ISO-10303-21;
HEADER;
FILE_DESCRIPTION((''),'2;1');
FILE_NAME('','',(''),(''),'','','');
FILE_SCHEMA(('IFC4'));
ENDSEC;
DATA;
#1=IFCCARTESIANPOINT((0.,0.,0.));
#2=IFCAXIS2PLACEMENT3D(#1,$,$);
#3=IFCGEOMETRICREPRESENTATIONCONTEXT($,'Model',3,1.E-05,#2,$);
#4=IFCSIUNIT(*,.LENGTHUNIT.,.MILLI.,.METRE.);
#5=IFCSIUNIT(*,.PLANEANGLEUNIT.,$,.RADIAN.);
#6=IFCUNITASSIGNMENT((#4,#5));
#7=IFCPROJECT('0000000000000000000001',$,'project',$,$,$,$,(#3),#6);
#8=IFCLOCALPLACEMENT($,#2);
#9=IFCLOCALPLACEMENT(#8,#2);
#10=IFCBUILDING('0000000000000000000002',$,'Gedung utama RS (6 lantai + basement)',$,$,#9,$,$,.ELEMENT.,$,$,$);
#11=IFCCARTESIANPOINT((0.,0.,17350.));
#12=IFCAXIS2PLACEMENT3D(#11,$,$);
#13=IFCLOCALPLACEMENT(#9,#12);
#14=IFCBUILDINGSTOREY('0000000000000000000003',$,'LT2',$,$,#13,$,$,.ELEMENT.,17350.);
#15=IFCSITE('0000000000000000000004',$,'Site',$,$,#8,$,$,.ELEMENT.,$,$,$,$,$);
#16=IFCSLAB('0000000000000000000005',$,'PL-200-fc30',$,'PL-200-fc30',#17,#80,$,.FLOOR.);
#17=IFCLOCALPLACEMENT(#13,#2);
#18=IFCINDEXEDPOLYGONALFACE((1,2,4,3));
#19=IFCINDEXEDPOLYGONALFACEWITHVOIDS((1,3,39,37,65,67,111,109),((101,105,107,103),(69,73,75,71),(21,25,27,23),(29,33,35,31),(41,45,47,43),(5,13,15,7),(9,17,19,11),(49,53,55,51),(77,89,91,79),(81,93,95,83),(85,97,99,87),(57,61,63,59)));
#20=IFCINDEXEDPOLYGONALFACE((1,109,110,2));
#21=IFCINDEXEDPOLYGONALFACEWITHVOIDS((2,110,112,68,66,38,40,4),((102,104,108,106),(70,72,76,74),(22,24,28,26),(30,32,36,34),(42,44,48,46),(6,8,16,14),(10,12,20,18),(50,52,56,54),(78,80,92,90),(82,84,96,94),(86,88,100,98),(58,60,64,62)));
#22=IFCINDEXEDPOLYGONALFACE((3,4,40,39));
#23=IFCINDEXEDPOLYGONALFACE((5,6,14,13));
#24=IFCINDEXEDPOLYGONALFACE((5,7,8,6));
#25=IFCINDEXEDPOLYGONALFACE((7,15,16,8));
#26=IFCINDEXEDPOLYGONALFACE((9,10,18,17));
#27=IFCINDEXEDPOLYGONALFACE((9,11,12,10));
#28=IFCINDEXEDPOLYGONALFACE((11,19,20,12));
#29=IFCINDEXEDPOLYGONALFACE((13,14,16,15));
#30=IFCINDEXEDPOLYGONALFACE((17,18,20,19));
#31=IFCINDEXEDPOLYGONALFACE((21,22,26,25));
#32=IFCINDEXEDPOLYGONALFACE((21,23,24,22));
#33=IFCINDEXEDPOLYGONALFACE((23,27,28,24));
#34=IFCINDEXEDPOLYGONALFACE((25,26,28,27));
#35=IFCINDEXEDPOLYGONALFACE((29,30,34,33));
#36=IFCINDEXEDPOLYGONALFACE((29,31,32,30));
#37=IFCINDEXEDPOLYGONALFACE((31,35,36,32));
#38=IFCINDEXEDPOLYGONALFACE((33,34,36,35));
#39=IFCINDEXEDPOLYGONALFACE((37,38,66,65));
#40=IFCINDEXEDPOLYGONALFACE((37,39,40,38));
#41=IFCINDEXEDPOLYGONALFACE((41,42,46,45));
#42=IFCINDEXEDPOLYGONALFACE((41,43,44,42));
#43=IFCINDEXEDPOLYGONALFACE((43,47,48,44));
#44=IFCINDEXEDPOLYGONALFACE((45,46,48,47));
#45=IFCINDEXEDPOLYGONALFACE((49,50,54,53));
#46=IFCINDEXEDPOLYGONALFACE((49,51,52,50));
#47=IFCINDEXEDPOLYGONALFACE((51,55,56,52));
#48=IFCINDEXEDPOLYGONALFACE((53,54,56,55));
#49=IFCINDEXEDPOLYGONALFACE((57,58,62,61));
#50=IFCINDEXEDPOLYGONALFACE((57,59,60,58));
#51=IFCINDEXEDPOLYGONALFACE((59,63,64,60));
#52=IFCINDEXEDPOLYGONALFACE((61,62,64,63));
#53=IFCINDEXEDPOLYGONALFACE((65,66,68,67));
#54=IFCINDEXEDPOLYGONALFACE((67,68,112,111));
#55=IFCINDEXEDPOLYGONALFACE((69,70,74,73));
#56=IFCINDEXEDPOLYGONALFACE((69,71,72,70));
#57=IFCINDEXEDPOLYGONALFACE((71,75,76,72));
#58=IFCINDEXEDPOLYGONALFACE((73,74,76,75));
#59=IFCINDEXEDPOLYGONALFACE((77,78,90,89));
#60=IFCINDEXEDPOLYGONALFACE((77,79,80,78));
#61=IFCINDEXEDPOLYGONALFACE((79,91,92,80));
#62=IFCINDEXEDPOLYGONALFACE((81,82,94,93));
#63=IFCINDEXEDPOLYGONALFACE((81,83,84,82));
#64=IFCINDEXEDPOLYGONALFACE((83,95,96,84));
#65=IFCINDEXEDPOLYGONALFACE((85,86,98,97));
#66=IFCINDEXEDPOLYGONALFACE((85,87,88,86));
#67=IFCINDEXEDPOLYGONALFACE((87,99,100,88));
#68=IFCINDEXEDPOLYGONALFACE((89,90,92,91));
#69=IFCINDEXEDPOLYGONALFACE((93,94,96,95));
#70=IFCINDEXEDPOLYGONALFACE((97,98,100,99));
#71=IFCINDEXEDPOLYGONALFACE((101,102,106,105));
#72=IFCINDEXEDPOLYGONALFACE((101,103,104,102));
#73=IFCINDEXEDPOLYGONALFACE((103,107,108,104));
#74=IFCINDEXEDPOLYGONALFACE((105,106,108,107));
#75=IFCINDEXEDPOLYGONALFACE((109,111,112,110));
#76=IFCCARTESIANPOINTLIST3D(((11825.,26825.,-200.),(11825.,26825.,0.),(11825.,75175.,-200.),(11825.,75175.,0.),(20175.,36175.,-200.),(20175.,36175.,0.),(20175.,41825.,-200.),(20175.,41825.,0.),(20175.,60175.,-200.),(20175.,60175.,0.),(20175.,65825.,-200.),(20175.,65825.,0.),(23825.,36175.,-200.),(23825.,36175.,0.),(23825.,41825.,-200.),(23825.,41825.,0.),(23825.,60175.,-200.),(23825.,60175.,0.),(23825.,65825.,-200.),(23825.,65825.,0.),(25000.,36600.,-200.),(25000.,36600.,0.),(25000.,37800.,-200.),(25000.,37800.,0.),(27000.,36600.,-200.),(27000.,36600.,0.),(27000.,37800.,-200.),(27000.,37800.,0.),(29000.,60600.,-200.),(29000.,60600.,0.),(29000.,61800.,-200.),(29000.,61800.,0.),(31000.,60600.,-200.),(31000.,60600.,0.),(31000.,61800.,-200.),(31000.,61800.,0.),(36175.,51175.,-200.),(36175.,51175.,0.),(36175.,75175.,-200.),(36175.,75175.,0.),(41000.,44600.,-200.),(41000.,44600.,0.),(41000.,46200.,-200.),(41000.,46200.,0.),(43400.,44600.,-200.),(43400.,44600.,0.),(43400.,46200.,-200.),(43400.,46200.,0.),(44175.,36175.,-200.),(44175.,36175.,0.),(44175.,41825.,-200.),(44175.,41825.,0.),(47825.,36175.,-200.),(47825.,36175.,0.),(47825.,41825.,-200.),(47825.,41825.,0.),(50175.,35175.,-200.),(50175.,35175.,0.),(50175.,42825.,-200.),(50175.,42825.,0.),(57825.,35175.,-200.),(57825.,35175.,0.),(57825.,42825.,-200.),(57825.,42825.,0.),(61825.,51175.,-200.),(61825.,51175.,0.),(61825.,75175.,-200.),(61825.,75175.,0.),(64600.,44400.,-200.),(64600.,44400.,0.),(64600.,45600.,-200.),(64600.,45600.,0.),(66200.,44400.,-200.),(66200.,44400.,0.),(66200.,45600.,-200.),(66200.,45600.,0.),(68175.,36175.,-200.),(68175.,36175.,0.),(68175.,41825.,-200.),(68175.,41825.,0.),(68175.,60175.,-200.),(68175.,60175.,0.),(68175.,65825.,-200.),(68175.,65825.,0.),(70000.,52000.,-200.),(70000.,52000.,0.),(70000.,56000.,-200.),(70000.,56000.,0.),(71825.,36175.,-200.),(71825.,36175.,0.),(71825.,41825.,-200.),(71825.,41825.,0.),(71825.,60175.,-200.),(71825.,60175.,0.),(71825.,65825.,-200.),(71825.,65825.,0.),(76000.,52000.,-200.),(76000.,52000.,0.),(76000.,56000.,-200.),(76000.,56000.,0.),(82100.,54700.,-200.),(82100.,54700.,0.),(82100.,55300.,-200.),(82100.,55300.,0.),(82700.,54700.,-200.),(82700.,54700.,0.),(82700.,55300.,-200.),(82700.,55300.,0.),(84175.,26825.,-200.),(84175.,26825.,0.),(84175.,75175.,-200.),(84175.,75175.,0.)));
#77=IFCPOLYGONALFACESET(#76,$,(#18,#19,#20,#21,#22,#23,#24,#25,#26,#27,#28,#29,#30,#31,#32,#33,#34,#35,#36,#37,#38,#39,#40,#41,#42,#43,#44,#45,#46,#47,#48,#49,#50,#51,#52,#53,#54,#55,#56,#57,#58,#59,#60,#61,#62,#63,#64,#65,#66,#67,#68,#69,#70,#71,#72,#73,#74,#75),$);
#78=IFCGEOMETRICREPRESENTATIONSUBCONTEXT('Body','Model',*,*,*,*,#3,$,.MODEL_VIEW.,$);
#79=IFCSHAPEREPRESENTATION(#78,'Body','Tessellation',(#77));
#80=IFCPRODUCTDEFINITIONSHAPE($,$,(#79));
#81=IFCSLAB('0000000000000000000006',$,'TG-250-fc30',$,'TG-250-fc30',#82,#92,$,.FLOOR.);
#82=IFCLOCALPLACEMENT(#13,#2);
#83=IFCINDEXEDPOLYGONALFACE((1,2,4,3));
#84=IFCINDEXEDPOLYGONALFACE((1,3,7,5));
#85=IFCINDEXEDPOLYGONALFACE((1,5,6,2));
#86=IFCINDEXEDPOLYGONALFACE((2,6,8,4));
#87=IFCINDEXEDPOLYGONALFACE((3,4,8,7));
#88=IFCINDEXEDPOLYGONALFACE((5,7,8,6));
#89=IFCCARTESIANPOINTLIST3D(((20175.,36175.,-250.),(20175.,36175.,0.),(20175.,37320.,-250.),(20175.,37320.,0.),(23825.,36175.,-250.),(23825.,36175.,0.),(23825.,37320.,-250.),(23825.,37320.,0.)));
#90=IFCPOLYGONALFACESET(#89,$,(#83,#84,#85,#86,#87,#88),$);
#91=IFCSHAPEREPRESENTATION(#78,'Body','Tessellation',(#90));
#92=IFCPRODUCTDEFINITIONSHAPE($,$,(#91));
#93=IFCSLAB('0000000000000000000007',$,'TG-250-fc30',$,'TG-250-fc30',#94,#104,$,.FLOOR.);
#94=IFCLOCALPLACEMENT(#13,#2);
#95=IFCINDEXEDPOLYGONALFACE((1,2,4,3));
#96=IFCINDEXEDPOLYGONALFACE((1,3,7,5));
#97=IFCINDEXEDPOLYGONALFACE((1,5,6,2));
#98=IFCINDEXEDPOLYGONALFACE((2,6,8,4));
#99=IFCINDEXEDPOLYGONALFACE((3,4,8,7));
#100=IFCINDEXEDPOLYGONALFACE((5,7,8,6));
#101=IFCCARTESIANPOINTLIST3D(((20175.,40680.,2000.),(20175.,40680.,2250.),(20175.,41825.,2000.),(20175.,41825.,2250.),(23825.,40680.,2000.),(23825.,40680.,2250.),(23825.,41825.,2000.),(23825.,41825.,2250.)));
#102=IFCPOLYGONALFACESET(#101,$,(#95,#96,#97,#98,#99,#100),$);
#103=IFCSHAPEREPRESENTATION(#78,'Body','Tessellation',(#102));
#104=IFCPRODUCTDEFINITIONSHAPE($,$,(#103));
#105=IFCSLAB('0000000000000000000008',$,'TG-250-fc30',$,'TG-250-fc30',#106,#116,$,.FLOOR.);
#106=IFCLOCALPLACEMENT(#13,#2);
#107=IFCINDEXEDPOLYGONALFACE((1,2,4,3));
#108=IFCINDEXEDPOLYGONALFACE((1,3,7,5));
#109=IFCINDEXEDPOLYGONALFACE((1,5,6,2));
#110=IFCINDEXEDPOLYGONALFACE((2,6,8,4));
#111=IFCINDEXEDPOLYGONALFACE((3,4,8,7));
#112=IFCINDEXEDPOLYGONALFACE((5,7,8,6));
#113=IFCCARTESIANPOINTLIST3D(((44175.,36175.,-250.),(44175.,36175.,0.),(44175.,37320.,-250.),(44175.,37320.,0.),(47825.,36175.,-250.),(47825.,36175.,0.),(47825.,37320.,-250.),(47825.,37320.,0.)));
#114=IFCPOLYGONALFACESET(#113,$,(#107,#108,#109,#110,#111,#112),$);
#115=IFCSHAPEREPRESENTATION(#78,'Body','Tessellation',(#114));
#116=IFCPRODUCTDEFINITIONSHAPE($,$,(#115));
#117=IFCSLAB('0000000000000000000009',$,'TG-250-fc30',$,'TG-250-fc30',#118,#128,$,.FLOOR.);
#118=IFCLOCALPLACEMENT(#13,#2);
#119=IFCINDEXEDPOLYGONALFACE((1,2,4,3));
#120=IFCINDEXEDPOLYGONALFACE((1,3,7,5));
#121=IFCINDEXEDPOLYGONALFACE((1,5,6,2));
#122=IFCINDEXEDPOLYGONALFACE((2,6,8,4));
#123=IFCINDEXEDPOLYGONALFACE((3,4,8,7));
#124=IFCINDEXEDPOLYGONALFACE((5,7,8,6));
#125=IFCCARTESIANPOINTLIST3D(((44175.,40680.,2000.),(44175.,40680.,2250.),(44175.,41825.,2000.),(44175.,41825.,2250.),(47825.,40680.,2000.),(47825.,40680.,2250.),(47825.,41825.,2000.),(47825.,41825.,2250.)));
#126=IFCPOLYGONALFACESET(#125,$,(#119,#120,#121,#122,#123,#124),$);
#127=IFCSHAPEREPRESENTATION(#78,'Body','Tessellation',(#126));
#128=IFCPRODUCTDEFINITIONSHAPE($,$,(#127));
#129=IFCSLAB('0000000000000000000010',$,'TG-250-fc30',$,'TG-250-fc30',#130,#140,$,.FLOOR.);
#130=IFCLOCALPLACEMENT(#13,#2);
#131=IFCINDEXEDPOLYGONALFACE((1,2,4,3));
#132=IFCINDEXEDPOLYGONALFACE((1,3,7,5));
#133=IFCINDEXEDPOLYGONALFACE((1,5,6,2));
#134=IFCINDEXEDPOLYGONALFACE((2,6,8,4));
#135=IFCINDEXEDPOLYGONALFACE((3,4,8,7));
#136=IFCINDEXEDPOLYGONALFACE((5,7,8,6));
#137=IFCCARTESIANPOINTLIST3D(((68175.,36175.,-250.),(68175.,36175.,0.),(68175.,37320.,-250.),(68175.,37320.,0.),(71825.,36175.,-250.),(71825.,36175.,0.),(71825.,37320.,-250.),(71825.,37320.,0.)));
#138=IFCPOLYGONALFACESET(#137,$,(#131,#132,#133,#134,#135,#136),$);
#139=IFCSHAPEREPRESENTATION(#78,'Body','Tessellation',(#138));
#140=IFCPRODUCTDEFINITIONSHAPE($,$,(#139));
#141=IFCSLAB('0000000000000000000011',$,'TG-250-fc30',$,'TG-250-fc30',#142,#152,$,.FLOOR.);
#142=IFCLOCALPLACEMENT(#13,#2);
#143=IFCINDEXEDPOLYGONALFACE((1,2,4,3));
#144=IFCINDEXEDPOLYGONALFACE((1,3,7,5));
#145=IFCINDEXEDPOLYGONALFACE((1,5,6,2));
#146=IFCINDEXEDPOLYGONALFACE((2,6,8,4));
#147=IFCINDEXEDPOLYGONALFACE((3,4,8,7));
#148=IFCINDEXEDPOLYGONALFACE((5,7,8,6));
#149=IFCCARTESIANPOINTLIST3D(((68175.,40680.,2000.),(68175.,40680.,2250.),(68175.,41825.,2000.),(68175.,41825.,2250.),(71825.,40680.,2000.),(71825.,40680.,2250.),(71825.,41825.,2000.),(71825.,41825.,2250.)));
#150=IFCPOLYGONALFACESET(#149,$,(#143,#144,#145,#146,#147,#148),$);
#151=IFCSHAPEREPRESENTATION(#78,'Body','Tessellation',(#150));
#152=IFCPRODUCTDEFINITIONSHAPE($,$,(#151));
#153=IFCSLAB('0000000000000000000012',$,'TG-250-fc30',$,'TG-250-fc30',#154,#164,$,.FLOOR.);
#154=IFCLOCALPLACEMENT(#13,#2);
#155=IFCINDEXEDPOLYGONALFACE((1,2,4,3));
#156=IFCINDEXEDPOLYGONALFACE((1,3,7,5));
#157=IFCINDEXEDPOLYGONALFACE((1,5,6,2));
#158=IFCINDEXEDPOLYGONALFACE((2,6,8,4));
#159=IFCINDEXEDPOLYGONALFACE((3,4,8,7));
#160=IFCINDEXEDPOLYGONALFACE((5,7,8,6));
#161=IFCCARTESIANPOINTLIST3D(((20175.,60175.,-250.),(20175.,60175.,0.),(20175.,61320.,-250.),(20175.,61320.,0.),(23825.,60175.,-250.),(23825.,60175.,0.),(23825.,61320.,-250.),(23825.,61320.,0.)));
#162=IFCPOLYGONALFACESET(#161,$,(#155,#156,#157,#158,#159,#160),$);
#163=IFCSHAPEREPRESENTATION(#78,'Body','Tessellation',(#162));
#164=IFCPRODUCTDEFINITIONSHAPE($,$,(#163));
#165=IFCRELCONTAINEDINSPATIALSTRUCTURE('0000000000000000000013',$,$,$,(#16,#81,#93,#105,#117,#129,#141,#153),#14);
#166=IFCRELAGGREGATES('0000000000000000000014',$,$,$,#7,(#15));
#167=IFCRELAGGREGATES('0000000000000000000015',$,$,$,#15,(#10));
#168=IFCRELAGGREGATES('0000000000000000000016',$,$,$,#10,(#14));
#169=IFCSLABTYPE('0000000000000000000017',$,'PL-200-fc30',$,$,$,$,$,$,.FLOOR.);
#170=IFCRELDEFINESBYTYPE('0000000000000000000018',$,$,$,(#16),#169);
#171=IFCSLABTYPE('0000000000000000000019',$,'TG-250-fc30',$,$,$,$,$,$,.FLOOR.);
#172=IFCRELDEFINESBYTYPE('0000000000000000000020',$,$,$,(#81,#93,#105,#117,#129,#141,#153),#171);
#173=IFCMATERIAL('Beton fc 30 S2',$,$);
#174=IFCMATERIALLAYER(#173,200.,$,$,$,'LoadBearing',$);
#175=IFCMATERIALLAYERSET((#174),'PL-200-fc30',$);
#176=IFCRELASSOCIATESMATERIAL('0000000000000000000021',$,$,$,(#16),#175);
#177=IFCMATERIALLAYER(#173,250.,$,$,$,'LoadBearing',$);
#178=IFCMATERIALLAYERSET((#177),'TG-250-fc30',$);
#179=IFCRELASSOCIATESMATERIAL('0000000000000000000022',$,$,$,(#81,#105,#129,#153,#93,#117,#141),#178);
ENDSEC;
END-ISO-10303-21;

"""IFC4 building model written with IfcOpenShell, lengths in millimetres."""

from ifc_helpers import new_model, si_unit, frame, origin, place, context, subcontext, project, spatial, polyline, outline, extrude, material, layer, layer_set, layer_usage, type_object, element, save


model = new_model("IFC4")

# Units and contexts
model_context = context("Model", 3, precision=1e-05, world=origin())
body_context = subcontext(model_context, "Body", "Model", "MODEL_VIEW")
ifc_project = project(units=[si_unit("LENGTHUNIT", "METRE", prefix="MILLI"), si_unit("PLANEANGLEUNIT", "RADIAN")], contexts=[model_context])

# Site, building, storey
site_placement = place(None, origin())
site = spatial("IfcSite", under=ifc_project, at=site_placement, Name="Site", CompositionType="ELEMENT")
building_placement = place(site_placement, origin())
building = spatial("IfcBuilding", under=site, at=building_placement, Name="Gedung utama RS (6 lantai + basement)", CompositionType="ELEMENT")
storey_placement = place(building_placement, frame((0.0, 0.0, 17350.0)))
storey = spatial("IfcBuildingStorey", under=building, at=storey_placement, Name="LT2", CompositionType="ELEMENT", Elevation=17350.0)

# Shared definitions
ifc_material = material(Name="Beton fc 30 S2")

# Shared definitions
ifc_layer_1 = layer(ifc_material, 200.0, Category="LoadBearing")
ifc_layer_set_1 = layer_set([ifc_layer_1], Name="PL-200-fc30")
slab_type_1 = type_object("IfcSlabType", Name="PL-200-fc30", PredefinedType="FLOOR")

# Slab, openings
ifc_layer_usage_1 = layer_usage(ifc_layer_set_1, "AXIS3", "NEGATIVE", 0.0)
slab_1_placement = place(storey_placement, origin())
slab_1 = element("IfcSlab", 1, at=slab_1_placement, inside=storey, type_object=slab_type_1, material=ifc_layer_usage_1, Name="PL-200-fc30", ObjectType="PL-200-fc30", PredefinedType="FLOOR", context=body_context, shape_type="SweptSolid", body=[
    extrude(outline(polyline([(61825.0, 75175.0), (61825.0, 51175.0), (36175.0, 51175.0), (36175.0, 75175.0), (11825.0, 75175.0), (11825.0, 26825.0), (84175.0, 26825.0), (84175.0, 75175.0), (61825.0, 75175.0)]), holes=[polyline([(23825.0, 36175.0), (23825.0, 41825.0), (20175.0, 41825.0), (20175.0, 36175.0), (23825.0, 36175.0)]), polyline([(47825.0, 36175.0), (47825.0, 41825.0), (44175.0, 41825.0), (44175.0, 36175.0), (47825.0, 36175.0)]), polyline([(71825.0, 36175.0), (71825.0, 41825.0), (68175.0, 41825.0), (68175.0, 36175.0), (71825.0, 36175.0)]), polyline([(23825.0, 60175.0), (23825.0, 65825.0), (20175.0, 65825.0), (20175.0, 60175.0), (23825.0, 60175.0)]), polyline([(71825.0, 60175.0), (71825.0, 65825.0), (68175.0, 65825.0), (68175.0, 60175.0), (71825.0, 60175.0)]), polyline([(76000.0, 52000.0), (76000.0, 56000.0), (70000.0, 56000.0), (70000.0, 52000.0), (76000.0, 52000.0)])]), frame((0.0, 0.0, -200.0)), (0.0, 0.0, 1.0), 200.0),
])
opening_1_placement = place(slab_1_placement, frame((0.0, 0.0, -4400.0)))
element("IfcOpeningElement", 2, at=opening_1_placement, cuts=slab_1, PredefinedType="OPENING", context=body_context, shape_type="SweptSolid", body=[
    extrude(outline(polyline([(27000.0, 36600.0), (27000.0, 37800.0), (25000.0, 37800.0), (25000.0, 36600.0), (27000.0, 36600.0)])), origin(), (0.0, 0.0, 1.0), 25800.0),
])
opening_2_placement = place(slab_1_placement, frame((0.0, 0.0, -4400.0)))
element("IfcOpeningElement", 3, at=opening_2_placement, cuts=slab_1, PredefinedType="OPENING", context=body_context, shape_type="SweptSolid", body=[
    extrude(outline(polyline([(43400.0, 44600.0), (43400.0, 46200.0), (41000.0, 46200.0), (41000.0, 44600.0), (43400.0, 44600.0)])), origin(), (0.0, 0.0, 1.0), 25800.0),
])
opening_3_placement = place(slab_1_placement, frame((0.0, 0.0, -4400.0)))
element("IfcOpeningElement", 4, at=opening_3_placement, cuts=slab_1, PredefinedType="OPENING", context=body_context, shape_type="SweptSolid", body=[
    extrude(outline(polyline([(66200.0, 44400.0), (66200.0, 45600.0), (64600.0, 45600.0), (64600.0, 44400.0), (66200.0, 44400.0)])), origin(), (0.0, 0.0, 1.0), 25800.0),
])
opening_4_placement = place(slab_1_placement, frame((0.0, 0.0, -4400.0)))
element("IfcOpeningElement", 5, at=opening_4_placement, cuts=slab_1, PredefinedType="OPENING", context=body_context, shape_type="SweptSolid", body=[
    extrude(outline(polyline([(31000.0, 60600.0), (31000.0, 61800.0), (29000.0, 61800.0), (29000.0, 60600.0), (31000.0, 60600.0)])), origin(), (0.0, 0.0, 1.0), 13200.0),
])
opening_5_placement = place(slab_1_placement, frame((0.0, 0.0, -4400.0)))
element("IfcOpeningElement", 6, at=opening_5_placement, cuts=slab_1, PredefinedType="OPENING", context=body_context, shape_type="SweptSolid", body=[
    extrude(outline(polyline([(82700.0, 54700.0), (82700.0, 55300.0), (82100.0, 55300.0), (82100.0, 54700.0), (82700.0, 54700.0)])), origin(), (0.0, 0.0, 1.0), 9000.0),
])
opening_6_placement = place(slab_1_placement, frame((0.0, 0.0, -4400.0)))
element("IfcOpeningElement", 7, at=opening_6_placement, cuts=slab_1, PredefinedType="OPENING", context=body_context, shape_type="SweptSolid", body=[
    extrude(outline(polyline([(57825.0, 35175.0), (57825.0, 42825.0), (50175.0, 42825.0), (50175.0, 35175.0), (57825.0, 35175.0)])), origin(), (0.0, 0.0, 1.0), 21600.0),
])

# Slabs
ifc_layer_2 = layer(ifc_material, 250.0, Category="LoadBearing")
ifc_layer_set_2 = layer_set([ifc_layer_2], Name="TG-250-fc30")
ifc_layer_usage_2 = layer_usage(ifc_layer_set_2, "AXIS3", "NEGATIVE", 0.0)
slab_type_2 = type_object("IfcSlabType", Name="TG-250-fc30", PredefinedType="FLOOR")
slab_2_placement = place(storey_placement, origin())
element("IfcSlab", 8, at=slab_2_placement, inside=storey, type_object=slab_type_2, material=ifc_layer_usage_2, Name="TG-250-fc30", ObjectType="TG-250-fc30", PredefinedType="FLOOR", context=body_context, shape_type="SweptSolid", body=[
    extrude(outline(polyline([(23825.0, 36175.0), (23825.0, 37320.0), (20175.0, 37320.0), (20175.0, 36175.0), (23825.0, 36175.0)])), frame((0.0, 0.0, -250.0)), (0.0, 0.0, 1.0), 250.0),
])
ifc_layer_usage_3 = layer_usage(ifc_layer_set_2, "AXIS3", "NEGATIVE", 2250.0)
slab_3_placement = place(storey_placement, origin())
element("IfcSlab", 9, at=slab_3_placement, inside=storey, type_object=slab_type_2, material=ifc_layer_usage_3, Name="TG-250-fc30", ObjectType="TG-250-fc30", PredefinedType="FLOOR", context=body_context, shape_type="SweptSolid", body=[
    extrude(outline(polyline([(23825.0, 40680.0), (23825.0, 41825.0), (20175.0, 41825.0), (20175.0, 40680.0), (23825.0, 40680.0)])), frame((0.0, 0.0, 2000.0)), (0.0, 0.0, 1.0), 250.0),
])
slab_4_placement = place(storey_placement, origin())
element("IfcSlab", 10, at=slab_4_placement, inside=storey, type_object=slab_type_2, material=ifc_layer_usage_2, Name="TG-250-fc30", ObjectType="TG-250-fc30", PredefinedType="FLOOR", context=body_context, shape_type="SweptSolid", body=[
    extrude(outline(polyline([(47825.0, 36175.0), (47825.0, 37320.0), (44175.0, 37320.0), (44175.0, 36175.0), (47825.0, 36175.0)])), frame((0.0, 0.0, -250.0)), (0.0, 0.0, 1.0), 250.0),
])
slab_5_placement = place(storey_placement, origin())
element("IfcSlab", 11, at=slab_5_placement, inside=storey, type_object=slab_type_2, material=ifc_layer_usage_3, Name="TG-250-fc30", ObjectType="TG-250-fc30", PredefinedType="FLOOR", context=body_context, shape_type="SweptSolid", body=[
    extrude(outline(polyline([(47825.0, 40680.0), (47825.0, 41825.0), (44175.0, 41825.0), (44175.0, 40680.0), (47825.0, 40680.0)])), frame((0.0, 0.0, 2000.0)), (0.0, 0.0, 1.0), 250.0),
])
slab_6_placement = place(storey_placement, origin())
element("IfcSlab", 12, at=slab_6_placement, inside=storey, type_object=slab_type_2, material=ifc_layer_usage_2, Name="TG-250-fc30", ObjectType="TG-250-fc30", PredefinedType="FLOOR", context=body_context, shape_type="SweptSolid", body=[
    extrude(outline(polyline([(71825.0, 36175.0), (71825.0, 37320.0), (68175.0, 37320.0), (68175.0, 36175.0), (71825.0, 36175.0)])), frame((0.0, 0.0, -250.0)), (0.0, 0.0, 1.0), 250.0),
])
slab_7_placement = place(storey_placement, origin())
element("IfcSlab", 13, at=slab_7_placement, inside=storey, type_object=slab_type_2, material=ifc_layer_usage_3, Name="TG-250-fc30", ObjectType="TG-250-fc30", PredefinedType="FLOOR", context=body_context, shape_type="SweptSolid", body=[
    extrude(outline(polyline([(71825.0, 40680.0), (71825.0, 41825.0), (68175.0, 41825.0), (68175.0, 40680.0), (71825.0, 40680.0)])), frame((0.0, 0.0, 2000.0)), (0.0, 0.0, 1.0), 250.0),
])
slab_8_placement = place(storey_placement, origin())
element("IfcSlab", 14, at=slab_8_placement, inside=storey, type_object=slab_type_2, material=ifc_layer_usage_2, Name="TG-250-fc30", ObjectType="TG-250-fc30", PredefinedType="FLOOR", context=body_context, shape_type="SweptSolid", body=[
    extrude(outline(polyline([(23825.0, 60175.0), (23825.0, 61320.0), (20175.0, 61320.0), (20175.0, 60175.0), (23825.0, 60175.0)])), frame((0.0, 0.0, -250.0)), (0.0, 0.0, 1.0), 250.0),
])

save(model, "model.ifc")
